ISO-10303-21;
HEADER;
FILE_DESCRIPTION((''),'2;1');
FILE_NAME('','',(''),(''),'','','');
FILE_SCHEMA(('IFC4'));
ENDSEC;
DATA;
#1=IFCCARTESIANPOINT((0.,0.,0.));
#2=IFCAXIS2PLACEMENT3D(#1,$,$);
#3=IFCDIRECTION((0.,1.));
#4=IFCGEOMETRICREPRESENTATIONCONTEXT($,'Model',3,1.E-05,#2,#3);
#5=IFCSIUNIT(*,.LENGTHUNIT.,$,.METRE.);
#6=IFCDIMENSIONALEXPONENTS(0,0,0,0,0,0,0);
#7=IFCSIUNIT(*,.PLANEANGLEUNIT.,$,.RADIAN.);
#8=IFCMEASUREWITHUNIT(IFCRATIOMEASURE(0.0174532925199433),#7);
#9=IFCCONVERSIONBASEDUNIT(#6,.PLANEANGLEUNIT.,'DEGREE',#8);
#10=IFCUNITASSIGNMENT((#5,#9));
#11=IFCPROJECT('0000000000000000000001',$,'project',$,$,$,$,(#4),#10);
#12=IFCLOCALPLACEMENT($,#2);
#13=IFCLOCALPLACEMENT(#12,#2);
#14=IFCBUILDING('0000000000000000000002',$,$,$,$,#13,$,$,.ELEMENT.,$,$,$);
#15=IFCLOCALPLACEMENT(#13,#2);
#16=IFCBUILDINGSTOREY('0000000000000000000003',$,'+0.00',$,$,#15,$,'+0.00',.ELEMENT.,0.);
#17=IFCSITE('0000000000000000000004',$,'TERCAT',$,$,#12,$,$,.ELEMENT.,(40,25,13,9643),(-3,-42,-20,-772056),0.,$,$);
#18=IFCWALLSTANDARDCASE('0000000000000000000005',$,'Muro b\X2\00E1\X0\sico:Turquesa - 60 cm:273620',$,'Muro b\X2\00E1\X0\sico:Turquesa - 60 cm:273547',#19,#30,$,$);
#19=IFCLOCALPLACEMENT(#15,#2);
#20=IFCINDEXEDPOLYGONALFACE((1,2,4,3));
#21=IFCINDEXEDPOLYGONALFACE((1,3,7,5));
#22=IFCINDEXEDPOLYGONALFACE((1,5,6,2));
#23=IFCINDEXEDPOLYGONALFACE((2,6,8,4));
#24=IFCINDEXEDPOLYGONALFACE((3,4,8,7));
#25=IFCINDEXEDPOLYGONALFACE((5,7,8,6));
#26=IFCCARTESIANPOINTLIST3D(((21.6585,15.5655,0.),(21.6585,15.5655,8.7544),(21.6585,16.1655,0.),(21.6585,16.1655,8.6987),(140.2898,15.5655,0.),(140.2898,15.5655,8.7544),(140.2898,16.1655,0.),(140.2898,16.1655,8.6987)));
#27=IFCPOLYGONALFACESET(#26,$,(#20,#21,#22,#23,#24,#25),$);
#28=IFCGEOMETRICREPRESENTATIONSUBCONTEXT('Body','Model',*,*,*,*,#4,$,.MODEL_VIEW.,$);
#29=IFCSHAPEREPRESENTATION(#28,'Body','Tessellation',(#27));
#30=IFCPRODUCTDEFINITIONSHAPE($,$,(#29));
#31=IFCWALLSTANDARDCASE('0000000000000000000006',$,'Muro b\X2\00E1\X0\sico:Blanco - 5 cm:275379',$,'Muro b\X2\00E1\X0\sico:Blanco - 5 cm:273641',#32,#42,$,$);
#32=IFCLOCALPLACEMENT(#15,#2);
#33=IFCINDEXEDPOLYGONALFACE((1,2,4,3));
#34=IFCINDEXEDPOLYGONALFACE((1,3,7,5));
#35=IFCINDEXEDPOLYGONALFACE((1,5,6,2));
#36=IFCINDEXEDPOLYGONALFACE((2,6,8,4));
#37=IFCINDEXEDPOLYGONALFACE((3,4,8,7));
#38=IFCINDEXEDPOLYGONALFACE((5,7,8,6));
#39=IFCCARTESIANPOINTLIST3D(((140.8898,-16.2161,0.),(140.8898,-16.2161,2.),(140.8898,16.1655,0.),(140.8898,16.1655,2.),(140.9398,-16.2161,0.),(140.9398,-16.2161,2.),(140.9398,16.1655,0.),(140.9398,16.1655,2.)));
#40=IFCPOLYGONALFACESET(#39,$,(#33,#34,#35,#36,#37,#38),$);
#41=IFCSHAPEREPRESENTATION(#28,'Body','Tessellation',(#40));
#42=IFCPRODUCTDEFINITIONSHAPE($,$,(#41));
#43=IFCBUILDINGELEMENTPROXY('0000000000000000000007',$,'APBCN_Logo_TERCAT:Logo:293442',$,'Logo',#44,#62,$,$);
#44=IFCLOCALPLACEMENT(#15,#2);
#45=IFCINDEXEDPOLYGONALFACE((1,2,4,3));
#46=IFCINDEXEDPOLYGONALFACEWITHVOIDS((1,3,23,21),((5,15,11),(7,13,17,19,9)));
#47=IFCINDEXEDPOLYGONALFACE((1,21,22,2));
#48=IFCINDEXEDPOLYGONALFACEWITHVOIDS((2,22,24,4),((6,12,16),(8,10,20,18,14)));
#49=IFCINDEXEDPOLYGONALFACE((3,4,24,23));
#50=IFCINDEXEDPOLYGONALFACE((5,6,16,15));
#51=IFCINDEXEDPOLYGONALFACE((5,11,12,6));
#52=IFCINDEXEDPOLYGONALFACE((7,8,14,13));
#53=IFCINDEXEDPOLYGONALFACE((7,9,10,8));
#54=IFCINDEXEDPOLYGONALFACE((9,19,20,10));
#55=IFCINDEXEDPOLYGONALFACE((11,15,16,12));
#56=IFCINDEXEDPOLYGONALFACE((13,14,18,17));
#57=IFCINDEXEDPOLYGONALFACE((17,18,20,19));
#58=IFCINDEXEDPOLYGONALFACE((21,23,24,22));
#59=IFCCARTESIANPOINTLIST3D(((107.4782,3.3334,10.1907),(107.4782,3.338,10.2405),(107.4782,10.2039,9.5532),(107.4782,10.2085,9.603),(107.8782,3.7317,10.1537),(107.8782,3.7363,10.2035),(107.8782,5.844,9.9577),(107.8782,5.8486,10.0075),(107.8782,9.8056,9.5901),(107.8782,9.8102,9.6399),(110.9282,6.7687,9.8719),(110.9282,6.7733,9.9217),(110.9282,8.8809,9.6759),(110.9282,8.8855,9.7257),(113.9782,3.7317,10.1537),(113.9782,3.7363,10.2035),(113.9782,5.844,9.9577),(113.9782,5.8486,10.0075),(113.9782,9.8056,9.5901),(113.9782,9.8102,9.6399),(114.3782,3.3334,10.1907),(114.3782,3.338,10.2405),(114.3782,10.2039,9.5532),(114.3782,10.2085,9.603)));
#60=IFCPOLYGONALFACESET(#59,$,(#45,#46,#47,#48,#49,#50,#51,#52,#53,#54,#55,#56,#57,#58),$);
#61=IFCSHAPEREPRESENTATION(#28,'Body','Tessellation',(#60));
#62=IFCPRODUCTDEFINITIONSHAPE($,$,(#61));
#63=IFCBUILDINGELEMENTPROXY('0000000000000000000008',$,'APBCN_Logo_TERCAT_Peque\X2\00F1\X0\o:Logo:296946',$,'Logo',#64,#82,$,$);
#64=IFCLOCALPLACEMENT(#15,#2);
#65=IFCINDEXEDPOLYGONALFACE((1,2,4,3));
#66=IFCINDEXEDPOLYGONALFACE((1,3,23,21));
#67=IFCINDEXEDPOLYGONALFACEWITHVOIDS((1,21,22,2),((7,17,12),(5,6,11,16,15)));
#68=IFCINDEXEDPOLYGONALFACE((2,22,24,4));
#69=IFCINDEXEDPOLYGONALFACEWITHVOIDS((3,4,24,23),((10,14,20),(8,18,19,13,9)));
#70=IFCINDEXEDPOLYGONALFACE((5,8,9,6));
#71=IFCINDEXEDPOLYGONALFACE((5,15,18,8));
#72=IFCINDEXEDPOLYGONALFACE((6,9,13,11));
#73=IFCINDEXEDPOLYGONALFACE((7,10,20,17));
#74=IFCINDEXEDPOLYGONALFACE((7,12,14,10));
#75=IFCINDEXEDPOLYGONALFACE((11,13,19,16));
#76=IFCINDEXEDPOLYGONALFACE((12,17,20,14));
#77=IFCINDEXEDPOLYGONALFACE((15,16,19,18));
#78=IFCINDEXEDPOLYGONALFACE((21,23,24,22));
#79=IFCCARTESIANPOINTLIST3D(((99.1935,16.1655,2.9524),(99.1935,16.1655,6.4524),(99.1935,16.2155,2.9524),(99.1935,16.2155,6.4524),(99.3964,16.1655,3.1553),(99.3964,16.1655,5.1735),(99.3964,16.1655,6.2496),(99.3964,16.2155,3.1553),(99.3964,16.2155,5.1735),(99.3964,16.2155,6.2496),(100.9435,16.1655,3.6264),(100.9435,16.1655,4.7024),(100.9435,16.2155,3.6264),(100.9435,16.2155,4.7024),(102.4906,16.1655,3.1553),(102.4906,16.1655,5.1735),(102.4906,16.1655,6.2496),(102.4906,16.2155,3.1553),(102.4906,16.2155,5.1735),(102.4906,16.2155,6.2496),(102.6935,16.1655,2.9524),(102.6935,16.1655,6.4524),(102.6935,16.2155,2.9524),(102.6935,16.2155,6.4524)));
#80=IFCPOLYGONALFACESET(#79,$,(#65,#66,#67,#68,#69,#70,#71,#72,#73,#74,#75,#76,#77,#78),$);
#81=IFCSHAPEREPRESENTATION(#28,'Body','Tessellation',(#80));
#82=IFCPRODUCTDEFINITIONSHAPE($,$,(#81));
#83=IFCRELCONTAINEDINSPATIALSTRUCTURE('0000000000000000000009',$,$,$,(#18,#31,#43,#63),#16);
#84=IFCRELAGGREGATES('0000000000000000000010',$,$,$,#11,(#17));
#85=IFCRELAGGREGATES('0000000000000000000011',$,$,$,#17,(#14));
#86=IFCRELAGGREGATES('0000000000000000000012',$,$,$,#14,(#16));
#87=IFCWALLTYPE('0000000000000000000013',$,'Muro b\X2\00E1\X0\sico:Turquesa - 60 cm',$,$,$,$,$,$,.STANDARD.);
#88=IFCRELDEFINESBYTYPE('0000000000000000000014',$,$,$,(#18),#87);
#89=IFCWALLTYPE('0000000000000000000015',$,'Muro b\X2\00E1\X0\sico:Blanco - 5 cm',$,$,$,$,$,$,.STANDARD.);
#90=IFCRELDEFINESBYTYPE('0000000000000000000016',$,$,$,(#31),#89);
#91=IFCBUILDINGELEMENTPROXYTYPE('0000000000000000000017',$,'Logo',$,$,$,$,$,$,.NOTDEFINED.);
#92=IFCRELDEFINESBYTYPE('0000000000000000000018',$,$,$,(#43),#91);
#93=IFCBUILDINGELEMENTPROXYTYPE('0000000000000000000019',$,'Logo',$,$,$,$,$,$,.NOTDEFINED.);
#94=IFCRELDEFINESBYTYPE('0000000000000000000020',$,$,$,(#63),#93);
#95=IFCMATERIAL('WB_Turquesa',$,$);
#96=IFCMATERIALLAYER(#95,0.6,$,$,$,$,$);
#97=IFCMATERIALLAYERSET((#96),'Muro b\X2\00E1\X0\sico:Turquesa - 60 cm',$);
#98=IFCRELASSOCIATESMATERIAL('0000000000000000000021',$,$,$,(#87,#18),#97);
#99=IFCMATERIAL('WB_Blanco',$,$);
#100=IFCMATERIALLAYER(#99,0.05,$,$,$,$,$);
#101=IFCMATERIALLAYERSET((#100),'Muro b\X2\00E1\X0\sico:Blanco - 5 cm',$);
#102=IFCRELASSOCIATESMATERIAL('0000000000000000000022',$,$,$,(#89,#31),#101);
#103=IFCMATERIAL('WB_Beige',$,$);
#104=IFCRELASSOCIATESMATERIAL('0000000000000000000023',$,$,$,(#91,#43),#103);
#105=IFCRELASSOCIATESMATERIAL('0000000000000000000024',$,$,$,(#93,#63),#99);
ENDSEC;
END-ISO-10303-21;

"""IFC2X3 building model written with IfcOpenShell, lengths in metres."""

from ifc_helpers import new_model, entity, si_unit, converted_unit, direction, frame, frame_2d, origin, place, context, subcontext, project, spatial, polyline, rectangle, outline, extrude, clip, bounded_halfspace, source, transform, mapped, material, layer, layer_set, layer_usage, type_object, type_shapes, element, save


model = new_model("IFC2X3")

# Units and contexts
model_context = context("Model", 3, precision=1e-05, world=origin(), true_north=direction((0.0, 1.0)))
body_context = subcontext(model_context, "Body", "Model", "MODEL_VIEW")
ifc_project = project(units=[si_unit("LENGTHUNIT", "METRE"), converted_unit("PLANEANGLEUNIT", "DEGREE", entity("IfcRatioMeasure", 0.0174532925199433), si_unit("PLANEANGLEUNIT", "RADIAN"), dimensions=[0, 0, 0, 0, 0, 0, 0])], contexts=[model_context])

# Site, building, storey
site_placement = place(None, origin())
site = spatial("IfcSite", under=ifc_project, at=site_placement, Name="TERCAT", CompositionType="ELEMENT", RefLatitude=(40, 25, 13, 9643), RefLongitude=(-3, -42, -20, -772056), RefElevation=0.0)
building_placement = place(site_placement, origin())
building = spatial("IfcBuilding", under=site, at=building_placement, CompositionType="ELEMENT")
storey_placement = place(building_placement, origin())
storey = spatial("IfcBuildingStorey", under=building, at=storey_placement, Name="+0.00", LongName="+0.00", CompositionType="ELEMENT", Elevation=0.0)

# Walls
ifc_material_1 = material(Name="WB_Turquesa")
ifc_layer_1 = layer(ifc_material_1, 0.6)
ifc_layer_set_1 = layer_set([ifc_layer_1], Name="Muro básico:Turquesa - 60 cm")
ifc_layer_usage_1 = layer_usage(ifc_layer_set_1, "AXIS2", "POSITIVE", -0.3)
wall_type_1 = type_object("IfcWallType", Name="Muro básico:Turquesa - 60 cm", PredefinedType="STANDARD", material=ifc_layer_set_1)
wall_1_placement = place(storey_placement, frame((140.2898, 15.8655, 0.0), z_axis=(0.0, 0.0, 1.0), x_axis=(-1.0, 0.0, 0.0)))
element("IfcWallStandardCase", 1, at=wall_1_placement, inside=storey, type_object=wall_type_1, material=ifc_layer_usage_1, Name="Muro básico:Turquesa - 60 cm:273620", ObjectType="Muro básico:Turquesa - 60 cm:273547", context=body_context, shape_type="Clipping", body=[
    clip(extrude(rectangle(XDim=118.6313, YDim=0.6, at=frame_2d((59.3157, 0.0), x_axis=(-1.0, 0.0))), origin(), (0.0, 0.0, 1.0), 8.7544), bounded_halfspace(frame((0.0, -0.3, 8.6987), z_axis=(0.0, -0.092394, 0.995723), x_axis=(0.0, 0.995723, 0.092394)), False, frame((0.0, -0.3, 8.6987), z_axis=(0.0, -0.092394, 0.995723), x_axis=(0.0, 0.995723, 0.092394)), polyline([(0.0, 0.0), (0.0, -118.6313), (0.6026, -118.6313), (0.6026, 0.0), (0.0, 0.0)]))),
])
ifc_material_2 = material(Name="WB_Blanco")
ifc_layer_2 = layer(ifc_material_2, 0.05)
ifc_layer_set_2 = layer_set([ifc_layer_2], Name="Muro básico:Blanco - 5 cm")
ifc_layer_usage_2 = layer_usage(ifc_layer_set_2, "AXIS2", "POSITIVE", -0.025)
wall_type_2 = type_object("IfcWallType", Name="Muro básico:Blanco - 5 cm", PredefinedType="STANDARD", material=ifc_layer_set_2)
wall_2_placement = place(storey_placement, frame((140.9148, 16.1655, 0.0), z_axis=(0.0, 0.0, 1.0), x_axis=(0.0, -1.0, 0.0)))
element("IfcWallStandardCase", 2, at=wall_2_placement, inside=storey, type_object=wall_type_2, material=ifc_layer_usage_2, Name="Muro básico:Blanco - 5 cm:275379", ObjectType="Muro básico:Blanco - 5 cm:273641", context=body_context, shape_type="SweptSolid", body=[
    extrude(rectangle(XDim=32.3816, YDim=0.05, at=frame_2d((16.1908, 0.0), x_axis=(-1.0, 0.0))), origin(), (0.0, 0.0, 1.0), 2.0),
])

# Building element proxies
ifc_material_3 = material(Name="WB_Beige")
building_element_proxy_type_1 = type_object("IfcBuildingElementProxyType", Name="Logo", PredefinedType="NOTDEFINED", material=ifc_material_3)
shared_shape_1 = source(origin(), body_context, "Body", "SweptSolid", [
    extrude(outline(polyline([(-3.45, -3.45), (3.45, -3.45), (3.45, 3.45), (-3.45, 3.45), (-3.45, -3.45)]), holes=[polyline([(3.05, -0.9287), (0.0, 2.1213), (-3.05, -0.9287), (-3.05, 3.05), (3.05, 3.05), (3.05, -0.9287)]), polyline([(-3.05, -3.05), (0.0, 0.0), (3.05, -3.05), (-3.05, -3.05)])]), frame((0.0, 0.0, 0.0), z_axis=(0.0, 0.0, 1.0), x_axis=(-1.0, 0.0, 0.0)), (0.0, 0.0, 1.0), 0.05),
])
type_shapes(building_element_proxy_type_1, [shared_shape_1])
proxy_1_placement = place(storey_placement, frame((110.9282, 6.7687, 9.8719), z_axis=(0.0, 0.092394, 0.995723), x_axis=(-1.0, 0.0, 0.0)))
element("IfcBuildingElementProxy", 3, at=proxy_1_placement, inside=storey, type_object=building_element_proxy_type_1, material=ifc_material_3, Name="APBCN_Logo_TERCAT:Logo:293442", ObjectType="Logo", context=body_context, shape_type="MappedRepresentation", body=[
    mapped(shared_shape_1, transform((0.0, 0.0, 0.0), scale=1.0)),
])
building_element_proxy_type_2 = type_object("IfcBuildingElementProxyType", Name="Logo", PredefinedType="NOTDEFINED", material=ifc_material_2)
shared_shape_2 = source(origin(), body_context, "Body", "SweptSolid", [
    extrude(outline(polyline([(-1.75, -1.75), (1.75, -1.75), (1.75, 1.75), (-1.75, 1.75), (-1.75, -1.75)]), holes=[polyline([(1.5471, -0.4711), (0.0, 1.076), (-1.5471, -0.4711), (-1.5471, 1.5471), (1.5471, 1.5471), (1.5471, -0.4711)]), polyline([(-1.5471, -1.5471), (0.0, 0.0), (1.5471, -1.5471), (-1.5471, -1.5471)])]), frame((0.0, 0.0, 0.0), z_axis=(0.0, 0.0, 1.0), x_axis=(-1.0, 0.0, 0.0)), (0.0, 0.0, 1.0), 0.05),
])
type_shapes(building_element_proxy_type_2, [shared_shape_2])
proxy_2_placement = place(storey_placement, frame((100.9435, 16.1655, 4.7024), z_axis=(0.0, 1.0, 0.0), x_axis=(-1.0, 0.0, 0.0)))
element("IfcBuildingElementProxy", 4, at=proxy_2_placement, inside=storey, type_object=building_element_proxy_type_2, material=ifc_material_2, Name="APBCN_Logo_TERCAT_Pequeño:Logo:296946", ObjectType="Logo", context=body_context, shape_type="MappedRepresentation", body=[
    mapped(shared_shape_2, transform((0.0, 0.0, 0.0), scale=1.0)),
])

save(model, "model.ifc")
